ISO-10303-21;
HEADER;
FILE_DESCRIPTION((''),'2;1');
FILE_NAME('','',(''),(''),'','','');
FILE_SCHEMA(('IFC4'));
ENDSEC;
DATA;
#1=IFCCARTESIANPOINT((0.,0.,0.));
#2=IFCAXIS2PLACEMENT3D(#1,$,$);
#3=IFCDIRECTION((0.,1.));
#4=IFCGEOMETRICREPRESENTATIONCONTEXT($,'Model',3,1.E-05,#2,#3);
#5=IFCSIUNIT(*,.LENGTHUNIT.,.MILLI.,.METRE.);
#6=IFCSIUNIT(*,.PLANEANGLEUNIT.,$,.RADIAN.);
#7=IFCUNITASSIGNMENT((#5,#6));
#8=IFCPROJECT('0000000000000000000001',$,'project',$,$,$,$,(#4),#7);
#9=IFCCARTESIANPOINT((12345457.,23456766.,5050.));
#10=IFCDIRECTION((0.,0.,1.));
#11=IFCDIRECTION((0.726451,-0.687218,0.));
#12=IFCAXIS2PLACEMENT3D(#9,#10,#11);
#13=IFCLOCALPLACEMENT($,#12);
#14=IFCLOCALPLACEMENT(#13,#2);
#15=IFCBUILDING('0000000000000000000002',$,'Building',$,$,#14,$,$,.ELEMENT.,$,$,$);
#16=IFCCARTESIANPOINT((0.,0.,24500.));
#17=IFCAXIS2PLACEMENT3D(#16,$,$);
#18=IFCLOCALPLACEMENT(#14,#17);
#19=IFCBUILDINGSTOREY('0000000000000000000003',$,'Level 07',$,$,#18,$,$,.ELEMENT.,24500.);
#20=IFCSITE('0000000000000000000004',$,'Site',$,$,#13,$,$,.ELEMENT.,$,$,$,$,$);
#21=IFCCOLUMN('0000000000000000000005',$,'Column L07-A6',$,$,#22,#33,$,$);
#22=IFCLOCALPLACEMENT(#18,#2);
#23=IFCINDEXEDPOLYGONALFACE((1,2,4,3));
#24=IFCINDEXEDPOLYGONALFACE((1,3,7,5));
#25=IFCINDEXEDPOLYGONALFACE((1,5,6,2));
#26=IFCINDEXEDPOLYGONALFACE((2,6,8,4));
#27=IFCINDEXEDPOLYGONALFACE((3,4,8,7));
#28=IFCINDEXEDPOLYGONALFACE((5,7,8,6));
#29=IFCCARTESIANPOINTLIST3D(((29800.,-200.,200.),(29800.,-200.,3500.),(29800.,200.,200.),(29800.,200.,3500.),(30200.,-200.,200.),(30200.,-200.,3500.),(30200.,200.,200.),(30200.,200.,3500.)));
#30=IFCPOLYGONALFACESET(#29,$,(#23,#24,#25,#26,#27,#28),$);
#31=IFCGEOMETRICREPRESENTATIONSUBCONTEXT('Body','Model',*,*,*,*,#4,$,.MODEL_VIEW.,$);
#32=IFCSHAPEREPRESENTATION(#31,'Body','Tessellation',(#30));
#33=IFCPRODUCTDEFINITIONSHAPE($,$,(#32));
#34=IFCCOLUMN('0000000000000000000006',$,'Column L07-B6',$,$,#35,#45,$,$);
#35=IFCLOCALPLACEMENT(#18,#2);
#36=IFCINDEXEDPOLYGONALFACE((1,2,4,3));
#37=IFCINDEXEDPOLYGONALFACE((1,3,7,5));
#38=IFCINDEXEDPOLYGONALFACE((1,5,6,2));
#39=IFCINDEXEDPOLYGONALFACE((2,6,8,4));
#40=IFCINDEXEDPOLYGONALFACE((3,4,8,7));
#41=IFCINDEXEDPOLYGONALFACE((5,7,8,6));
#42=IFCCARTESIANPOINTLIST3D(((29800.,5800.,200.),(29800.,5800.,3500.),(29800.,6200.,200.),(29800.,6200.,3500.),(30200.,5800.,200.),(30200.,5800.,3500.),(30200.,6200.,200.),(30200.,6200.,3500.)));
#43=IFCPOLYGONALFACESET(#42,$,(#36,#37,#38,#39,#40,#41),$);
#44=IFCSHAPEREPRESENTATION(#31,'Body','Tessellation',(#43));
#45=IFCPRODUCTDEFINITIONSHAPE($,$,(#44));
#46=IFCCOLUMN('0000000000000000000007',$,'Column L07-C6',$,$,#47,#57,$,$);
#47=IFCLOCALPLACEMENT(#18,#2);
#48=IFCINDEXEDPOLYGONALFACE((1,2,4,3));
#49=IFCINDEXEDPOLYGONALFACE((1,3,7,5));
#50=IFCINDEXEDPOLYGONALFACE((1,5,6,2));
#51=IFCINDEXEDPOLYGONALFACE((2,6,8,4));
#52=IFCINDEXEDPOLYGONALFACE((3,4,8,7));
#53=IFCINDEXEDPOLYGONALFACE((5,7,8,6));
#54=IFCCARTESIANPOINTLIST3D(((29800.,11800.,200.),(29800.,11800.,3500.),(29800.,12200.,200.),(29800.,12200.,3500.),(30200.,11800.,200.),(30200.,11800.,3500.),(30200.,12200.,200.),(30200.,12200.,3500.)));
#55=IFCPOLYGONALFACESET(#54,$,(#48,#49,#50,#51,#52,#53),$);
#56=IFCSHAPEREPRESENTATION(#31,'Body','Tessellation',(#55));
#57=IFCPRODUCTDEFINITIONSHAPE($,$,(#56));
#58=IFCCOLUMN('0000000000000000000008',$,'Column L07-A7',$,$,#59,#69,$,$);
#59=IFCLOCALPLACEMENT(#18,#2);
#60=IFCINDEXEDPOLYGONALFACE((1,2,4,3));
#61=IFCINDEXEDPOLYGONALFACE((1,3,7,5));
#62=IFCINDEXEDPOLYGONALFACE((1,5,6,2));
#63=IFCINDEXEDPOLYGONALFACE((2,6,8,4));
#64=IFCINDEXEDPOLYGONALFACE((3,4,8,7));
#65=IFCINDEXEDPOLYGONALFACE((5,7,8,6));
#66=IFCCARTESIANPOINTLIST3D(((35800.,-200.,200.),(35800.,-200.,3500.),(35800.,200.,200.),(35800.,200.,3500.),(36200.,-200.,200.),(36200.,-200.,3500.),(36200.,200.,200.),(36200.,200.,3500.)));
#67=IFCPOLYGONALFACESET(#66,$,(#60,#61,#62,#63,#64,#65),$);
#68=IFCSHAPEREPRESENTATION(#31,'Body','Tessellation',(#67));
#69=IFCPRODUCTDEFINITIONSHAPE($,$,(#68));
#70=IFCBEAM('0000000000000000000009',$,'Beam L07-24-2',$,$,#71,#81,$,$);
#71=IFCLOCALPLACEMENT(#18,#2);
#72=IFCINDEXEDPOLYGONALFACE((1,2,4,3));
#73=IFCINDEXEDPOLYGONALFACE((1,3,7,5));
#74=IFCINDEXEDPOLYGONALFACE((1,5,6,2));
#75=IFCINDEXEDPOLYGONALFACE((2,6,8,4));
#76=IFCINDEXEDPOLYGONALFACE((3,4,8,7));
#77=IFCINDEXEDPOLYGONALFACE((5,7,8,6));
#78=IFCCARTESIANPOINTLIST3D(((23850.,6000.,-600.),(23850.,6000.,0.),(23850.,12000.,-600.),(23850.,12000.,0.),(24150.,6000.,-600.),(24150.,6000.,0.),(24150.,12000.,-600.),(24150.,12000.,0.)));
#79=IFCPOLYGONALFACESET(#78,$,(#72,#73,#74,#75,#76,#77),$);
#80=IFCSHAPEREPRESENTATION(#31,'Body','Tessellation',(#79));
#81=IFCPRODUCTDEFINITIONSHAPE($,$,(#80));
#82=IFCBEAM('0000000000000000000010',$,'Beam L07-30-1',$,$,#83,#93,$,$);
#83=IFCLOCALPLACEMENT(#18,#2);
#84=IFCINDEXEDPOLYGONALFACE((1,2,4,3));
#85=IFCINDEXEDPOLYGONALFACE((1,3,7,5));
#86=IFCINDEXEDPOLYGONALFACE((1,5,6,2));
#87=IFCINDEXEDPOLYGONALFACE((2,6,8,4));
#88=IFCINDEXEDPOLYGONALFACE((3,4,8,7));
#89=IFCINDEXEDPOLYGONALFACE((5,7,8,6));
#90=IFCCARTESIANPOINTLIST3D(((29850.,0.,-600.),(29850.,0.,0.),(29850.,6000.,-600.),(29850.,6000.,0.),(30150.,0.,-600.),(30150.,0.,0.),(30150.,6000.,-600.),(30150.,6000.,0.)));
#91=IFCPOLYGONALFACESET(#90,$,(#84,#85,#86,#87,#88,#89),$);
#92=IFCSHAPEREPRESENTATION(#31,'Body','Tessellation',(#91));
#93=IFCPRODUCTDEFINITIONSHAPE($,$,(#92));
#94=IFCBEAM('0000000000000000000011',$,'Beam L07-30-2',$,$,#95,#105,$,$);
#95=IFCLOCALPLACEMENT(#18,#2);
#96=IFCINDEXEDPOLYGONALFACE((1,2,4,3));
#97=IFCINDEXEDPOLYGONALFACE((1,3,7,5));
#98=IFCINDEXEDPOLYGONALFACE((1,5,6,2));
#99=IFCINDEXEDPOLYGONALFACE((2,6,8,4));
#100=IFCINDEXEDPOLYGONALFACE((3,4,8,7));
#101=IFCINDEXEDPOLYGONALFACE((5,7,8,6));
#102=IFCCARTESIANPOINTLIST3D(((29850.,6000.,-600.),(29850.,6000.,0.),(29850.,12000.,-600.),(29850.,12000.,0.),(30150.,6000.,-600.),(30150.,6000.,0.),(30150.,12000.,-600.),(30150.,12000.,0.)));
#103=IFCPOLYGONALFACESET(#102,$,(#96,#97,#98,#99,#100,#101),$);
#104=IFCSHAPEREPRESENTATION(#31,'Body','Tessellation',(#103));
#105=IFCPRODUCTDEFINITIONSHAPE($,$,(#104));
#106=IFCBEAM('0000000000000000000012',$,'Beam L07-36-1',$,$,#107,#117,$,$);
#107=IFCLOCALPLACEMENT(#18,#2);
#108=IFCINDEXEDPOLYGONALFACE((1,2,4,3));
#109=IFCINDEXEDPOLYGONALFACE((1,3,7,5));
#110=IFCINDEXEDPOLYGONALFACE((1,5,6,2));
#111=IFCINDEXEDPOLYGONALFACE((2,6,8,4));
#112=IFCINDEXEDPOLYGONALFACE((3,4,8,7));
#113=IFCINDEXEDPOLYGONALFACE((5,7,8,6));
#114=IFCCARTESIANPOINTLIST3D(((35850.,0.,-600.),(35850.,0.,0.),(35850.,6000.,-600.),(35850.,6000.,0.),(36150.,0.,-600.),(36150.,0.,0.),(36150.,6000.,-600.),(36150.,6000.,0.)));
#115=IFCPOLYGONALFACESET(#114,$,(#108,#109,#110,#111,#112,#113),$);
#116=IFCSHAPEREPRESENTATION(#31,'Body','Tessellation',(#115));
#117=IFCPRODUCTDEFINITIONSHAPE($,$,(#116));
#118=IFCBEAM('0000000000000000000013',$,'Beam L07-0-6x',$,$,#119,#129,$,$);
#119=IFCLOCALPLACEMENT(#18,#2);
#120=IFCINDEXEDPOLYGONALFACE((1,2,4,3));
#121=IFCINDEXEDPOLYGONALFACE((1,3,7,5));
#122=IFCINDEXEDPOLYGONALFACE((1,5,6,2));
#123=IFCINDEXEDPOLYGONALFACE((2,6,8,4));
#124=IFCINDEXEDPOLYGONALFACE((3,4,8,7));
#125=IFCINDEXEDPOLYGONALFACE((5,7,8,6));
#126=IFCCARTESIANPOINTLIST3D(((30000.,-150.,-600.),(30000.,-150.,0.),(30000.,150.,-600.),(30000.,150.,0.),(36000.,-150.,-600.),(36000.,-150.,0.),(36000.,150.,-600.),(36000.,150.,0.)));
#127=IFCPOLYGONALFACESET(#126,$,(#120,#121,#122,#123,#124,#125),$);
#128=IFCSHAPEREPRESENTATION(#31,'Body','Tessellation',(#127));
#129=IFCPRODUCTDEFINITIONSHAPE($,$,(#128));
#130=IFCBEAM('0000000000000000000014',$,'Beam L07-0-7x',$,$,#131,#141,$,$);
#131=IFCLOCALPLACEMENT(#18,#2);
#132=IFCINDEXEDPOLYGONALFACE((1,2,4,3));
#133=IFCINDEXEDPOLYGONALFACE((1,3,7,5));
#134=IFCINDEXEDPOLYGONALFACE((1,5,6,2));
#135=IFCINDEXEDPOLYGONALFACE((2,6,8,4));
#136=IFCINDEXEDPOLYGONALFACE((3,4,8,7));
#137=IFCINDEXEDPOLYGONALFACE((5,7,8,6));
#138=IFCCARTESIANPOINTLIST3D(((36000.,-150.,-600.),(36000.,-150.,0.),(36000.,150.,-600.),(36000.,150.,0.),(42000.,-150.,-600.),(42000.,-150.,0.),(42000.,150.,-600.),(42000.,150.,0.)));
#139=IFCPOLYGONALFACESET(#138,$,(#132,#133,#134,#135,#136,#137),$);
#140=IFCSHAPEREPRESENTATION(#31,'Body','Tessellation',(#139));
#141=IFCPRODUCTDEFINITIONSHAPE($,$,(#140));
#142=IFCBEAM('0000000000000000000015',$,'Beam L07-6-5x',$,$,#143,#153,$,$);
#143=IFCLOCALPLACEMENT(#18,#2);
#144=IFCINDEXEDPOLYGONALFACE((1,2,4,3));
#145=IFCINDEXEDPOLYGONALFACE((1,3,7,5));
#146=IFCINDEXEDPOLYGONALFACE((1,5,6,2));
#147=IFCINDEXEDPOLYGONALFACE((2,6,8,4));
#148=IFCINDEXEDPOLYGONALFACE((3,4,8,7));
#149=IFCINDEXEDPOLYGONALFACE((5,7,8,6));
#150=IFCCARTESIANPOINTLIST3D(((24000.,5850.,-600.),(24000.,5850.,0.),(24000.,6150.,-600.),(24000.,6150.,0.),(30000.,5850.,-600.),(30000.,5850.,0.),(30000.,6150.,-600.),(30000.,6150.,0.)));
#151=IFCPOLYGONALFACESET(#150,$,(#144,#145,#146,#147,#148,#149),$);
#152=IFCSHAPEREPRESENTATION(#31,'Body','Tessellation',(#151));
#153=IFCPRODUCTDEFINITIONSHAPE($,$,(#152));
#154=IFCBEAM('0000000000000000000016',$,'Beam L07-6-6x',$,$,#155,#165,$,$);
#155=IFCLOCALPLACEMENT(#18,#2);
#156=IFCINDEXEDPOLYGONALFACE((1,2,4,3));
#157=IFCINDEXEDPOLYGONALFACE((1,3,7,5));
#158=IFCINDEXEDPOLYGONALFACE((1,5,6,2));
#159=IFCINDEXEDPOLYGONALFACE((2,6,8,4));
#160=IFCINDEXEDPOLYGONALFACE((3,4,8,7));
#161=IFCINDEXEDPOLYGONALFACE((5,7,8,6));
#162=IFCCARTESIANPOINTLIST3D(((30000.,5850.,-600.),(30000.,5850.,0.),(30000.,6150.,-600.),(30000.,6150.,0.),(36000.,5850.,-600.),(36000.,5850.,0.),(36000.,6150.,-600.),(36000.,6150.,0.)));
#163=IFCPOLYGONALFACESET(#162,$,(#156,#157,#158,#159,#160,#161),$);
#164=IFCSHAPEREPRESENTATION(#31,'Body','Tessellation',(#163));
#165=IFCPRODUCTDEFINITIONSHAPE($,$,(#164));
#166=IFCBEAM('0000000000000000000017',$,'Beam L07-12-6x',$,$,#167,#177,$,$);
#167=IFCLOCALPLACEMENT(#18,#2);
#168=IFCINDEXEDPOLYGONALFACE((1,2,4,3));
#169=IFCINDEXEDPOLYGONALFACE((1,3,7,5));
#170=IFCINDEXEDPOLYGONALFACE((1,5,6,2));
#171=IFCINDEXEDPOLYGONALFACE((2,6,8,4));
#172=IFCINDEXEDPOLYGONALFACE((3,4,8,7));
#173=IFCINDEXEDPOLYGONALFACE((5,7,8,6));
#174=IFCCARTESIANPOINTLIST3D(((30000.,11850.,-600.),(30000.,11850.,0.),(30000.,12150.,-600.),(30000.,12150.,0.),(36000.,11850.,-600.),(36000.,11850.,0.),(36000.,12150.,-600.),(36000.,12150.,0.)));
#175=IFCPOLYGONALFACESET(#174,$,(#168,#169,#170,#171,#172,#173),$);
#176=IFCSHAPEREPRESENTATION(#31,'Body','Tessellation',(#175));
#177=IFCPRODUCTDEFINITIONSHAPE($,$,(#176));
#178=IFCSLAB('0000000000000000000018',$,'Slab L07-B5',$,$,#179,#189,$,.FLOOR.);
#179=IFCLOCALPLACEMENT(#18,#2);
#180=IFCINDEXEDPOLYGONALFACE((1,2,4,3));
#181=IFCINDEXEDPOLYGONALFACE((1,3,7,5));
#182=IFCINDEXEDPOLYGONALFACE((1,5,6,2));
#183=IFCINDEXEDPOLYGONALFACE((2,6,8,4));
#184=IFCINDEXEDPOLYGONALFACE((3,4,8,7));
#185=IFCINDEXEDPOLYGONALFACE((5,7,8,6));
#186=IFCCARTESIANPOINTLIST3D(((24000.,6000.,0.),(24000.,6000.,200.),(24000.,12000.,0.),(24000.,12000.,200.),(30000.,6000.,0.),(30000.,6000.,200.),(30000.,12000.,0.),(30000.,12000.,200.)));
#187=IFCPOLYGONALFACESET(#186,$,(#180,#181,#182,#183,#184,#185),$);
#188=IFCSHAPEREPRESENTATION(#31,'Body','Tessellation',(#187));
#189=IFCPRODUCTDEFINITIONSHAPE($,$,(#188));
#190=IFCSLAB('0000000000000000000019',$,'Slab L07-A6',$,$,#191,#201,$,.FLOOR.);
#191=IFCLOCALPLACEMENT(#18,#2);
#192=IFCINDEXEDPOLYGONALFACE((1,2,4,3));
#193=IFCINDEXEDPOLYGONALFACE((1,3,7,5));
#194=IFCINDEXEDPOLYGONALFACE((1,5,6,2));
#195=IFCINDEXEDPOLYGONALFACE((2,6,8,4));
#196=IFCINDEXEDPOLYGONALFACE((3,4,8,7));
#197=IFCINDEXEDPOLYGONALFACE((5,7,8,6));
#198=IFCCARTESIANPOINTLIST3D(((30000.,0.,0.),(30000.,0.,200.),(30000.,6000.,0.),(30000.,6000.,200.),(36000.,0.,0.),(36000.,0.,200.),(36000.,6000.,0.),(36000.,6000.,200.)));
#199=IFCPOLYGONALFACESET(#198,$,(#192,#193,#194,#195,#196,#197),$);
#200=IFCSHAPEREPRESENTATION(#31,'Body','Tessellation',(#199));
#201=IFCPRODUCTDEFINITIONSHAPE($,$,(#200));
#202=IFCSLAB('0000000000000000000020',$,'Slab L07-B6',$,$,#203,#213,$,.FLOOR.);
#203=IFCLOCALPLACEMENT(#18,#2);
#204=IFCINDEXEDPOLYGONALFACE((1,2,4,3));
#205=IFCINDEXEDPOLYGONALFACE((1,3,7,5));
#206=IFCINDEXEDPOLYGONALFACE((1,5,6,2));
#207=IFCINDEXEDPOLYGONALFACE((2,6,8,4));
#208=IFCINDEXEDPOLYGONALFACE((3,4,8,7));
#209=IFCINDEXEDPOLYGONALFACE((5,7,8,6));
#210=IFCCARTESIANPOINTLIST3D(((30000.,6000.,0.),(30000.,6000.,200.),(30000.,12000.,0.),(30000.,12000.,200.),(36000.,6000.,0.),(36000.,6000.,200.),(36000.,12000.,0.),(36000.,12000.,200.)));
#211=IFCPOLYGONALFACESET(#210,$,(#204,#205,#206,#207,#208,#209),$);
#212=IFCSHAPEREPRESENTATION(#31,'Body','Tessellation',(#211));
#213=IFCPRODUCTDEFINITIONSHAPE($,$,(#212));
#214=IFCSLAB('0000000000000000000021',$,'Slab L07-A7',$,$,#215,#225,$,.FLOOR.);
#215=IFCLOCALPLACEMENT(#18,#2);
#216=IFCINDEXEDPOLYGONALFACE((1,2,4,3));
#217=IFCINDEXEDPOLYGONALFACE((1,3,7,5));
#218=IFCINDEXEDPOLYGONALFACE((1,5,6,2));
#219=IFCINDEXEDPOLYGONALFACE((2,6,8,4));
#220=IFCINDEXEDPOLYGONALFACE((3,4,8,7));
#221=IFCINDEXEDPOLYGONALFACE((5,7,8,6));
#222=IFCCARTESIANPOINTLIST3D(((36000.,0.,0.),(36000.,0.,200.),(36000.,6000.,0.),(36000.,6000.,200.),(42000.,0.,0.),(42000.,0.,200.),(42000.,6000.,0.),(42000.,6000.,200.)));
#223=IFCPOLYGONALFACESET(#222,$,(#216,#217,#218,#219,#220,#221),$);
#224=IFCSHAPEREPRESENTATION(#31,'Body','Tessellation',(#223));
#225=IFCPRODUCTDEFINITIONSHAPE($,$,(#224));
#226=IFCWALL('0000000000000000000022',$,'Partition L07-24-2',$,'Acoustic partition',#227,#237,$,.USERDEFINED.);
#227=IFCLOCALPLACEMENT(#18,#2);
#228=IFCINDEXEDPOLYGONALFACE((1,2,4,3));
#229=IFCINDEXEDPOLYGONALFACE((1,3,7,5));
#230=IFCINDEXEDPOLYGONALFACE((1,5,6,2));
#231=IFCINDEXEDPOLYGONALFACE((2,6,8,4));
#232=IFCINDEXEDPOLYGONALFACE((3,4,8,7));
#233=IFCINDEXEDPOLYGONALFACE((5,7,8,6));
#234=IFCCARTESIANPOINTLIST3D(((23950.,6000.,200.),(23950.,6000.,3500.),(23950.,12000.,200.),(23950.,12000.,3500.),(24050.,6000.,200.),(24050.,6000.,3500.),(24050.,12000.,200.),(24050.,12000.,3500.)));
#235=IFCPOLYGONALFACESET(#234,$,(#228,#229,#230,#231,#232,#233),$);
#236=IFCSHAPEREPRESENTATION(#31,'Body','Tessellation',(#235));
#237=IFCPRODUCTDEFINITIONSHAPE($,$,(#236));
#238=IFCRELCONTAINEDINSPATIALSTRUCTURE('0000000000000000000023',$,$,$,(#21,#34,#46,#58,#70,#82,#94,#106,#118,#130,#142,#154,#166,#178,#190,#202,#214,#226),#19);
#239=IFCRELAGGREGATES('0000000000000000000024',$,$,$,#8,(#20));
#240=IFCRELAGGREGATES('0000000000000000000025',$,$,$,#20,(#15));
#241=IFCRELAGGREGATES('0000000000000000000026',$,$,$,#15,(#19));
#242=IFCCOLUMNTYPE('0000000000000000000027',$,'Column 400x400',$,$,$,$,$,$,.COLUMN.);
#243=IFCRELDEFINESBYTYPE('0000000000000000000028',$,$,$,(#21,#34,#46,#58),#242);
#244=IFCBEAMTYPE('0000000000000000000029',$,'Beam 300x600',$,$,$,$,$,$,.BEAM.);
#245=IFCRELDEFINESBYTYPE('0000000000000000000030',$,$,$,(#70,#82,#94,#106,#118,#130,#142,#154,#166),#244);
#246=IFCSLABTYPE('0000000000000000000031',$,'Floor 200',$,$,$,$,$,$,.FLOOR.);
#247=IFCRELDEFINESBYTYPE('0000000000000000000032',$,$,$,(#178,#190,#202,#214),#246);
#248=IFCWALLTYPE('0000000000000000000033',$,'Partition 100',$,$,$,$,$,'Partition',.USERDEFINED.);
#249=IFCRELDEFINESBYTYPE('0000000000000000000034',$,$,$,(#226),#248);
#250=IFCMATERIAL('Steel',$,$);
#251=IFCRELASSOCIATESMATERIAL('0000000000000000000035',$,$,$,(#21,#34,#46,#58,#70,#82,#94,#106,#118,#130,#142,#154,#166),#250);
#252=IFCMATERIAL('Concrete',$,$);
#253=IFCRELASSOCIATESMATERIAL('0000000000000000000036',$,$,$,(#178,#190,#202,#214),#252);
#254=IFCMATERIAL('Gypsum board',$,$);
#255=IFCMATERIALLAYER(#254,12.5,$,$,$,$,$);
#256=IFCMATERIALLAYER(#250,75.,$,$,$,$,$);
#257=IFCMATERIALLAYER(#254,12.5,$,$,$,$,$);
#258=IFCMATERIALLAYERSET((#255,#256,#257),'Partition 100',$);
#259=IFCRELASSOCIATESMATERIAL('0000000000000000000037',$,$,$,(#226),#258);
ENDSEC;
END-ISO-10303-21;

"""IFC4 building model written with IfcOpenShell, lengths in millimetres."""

from ifc_helpers import new_model, si_unit, direction, frame, origin, place, context, subcontext, project, spatial, rectangle, extrude, material, layer, layer_set, layer_usage, type_object, element, save


model = new_model("IFC4")

# Units and contexts
model_context = context("Model", 3, precision=1e-05, world=origin(), true_north=direction((0.0, 1.0)))
body_context = subcontext(model_context, "Body", "Model", "MODEL_VIEW")
ifc_project = project(units=[si_unit("LENGTHUNIT", "METRE", prefix="MILLI"), si_unit("PLANEANGLEUNIT", "RADIAN")], contexts=[model_context])

# Site, building, storey
site_placement = place(None, frame((12345457.0, 23456766.0, 5050.0), z_axis=(0.0, 0.0, 1.0), x_axis=(0.726451, -0.687218, 0.0)))
site = spatial("IfcSite", under=ifc_project, at=site_placement, Name="Site", CompositionType="ELEMENT")
building_placement = place(site_placement, origin())
building = spatial("IfcBuilding", under=site, at=building_placement, Name="Building", CompositionType="ELEMENT")
storey_placement = place(building_placement, frame((0.0, 0.0, 24500.0)))
storey = spatial("IfcBuildingStorey", under=building, at=storey_placement, Name="Level 07", CompositionType="ELEMENT", Elevation=24500.0)

# Columns
ifc_material_1 = material(Name="Steel")
column_type = type_object("IfcColumnType", Name="Column 400x400", PredefinedType="COLUMN")
for number, where, name in (
    (1, (29800.0, -200.0, 200.0), "Column L07-A6"),
    (2, (29800.0, 5800.0, 200.0), "Column L07-B6"),
    (3, (29800.0, 11800.0, 200.0), "Column L07-C6"),
    (4, (35800.0, -200.0, 200.0), "Column L07-A7"),
):
    element("IfcColumn", number, at=place(storey_placement, frame(where)), inside=storey, type_object=column_type, material=ifc_material_1, Name=name, context=body_context, shape_type="SweptSolid", body=[
        extrude(rectangle(XDim=400.0, YDim=400.0), frame((200.0, 200.0, 0.0)), (0.0, 0.0, 1.0), 3300.0),
    ])

# Beams
beam_type = type_object("IfcBeamType", Name="Beam 300x600", PredefinedType="BEAM")
for number, where, name in (
    (5, (23850.0, 6000.0, -600.0), "Beam L07-24-2"),
    (6, (29850.0, 0.0, -600.0), "Beam L07-30-1"),
    (7, (29850.0, 6000.0, -600.0), "Beam L07-30-2"),
    (8, (35850.0, 0.0, -600.0), "Beam L07-36-1"),
):
    element("IfcBeam", number, at=place(storey_placement, frame(where)), inside=storey, type_object=beam_type, material=ifc_material_1, Name=name, context=body_context, shape_type="SweptSolid", body=[
        extrude(rectangle(XDim=300.0, YDim=6000.0), frame((150.0, 3000.0, 0.0)), (0.0, 0.0, 1.0), 600.0),
    ])
for number, where, name in (
    (9, (30000.0, -150.0, -600.0), "Beam L07-0-6x"),
    (10, (36000.0, -150.0, -600.0), "Beam L07-0-7x"),
    (11, (24000.0, 5850.0, -600.0), "Beam L07-6-5x"),
    (12, (30000.0, 5850.0, -600.0), "Beam L07-6-6x"),
    (13, (30000.0, 11850.0, -600.0), "Beam L07-12-6x"),
):
    element("IfcBeam", number, at=place(storey_placement, frame(where)), inside=storey, type_object=beam_type, material=ifc_material_1, Name=name, context=body_context, shape_type="SweptSolid", body=[
        extrude(rectangle(XDim=6000.0, YDim=300.0), frame((3000.0, 150.0, 0.0)), (0.0, 0.0, 1.0), 600.0),
    ])

# Slabs
ifc_material_2 = material(Name="Concrete")
slab_type = type_object("IfcSlabType", Name="Floor 200", PredefinedType="FLOOR")
for number, where, name in (
    (14, (24000.0, 6000.0, 0.0), "Slab L07-B5"),
    (15, (30000.0, 0.0, 0.0), "Slab L07-A6"),
    (16, (30000.0, 6000.0, 0.0), "Slab L07-B6"),
    (17, (36000.0, 0.0, 0.0), "Slab L07-A7"),
):
    element("IfcSlab", number, at=place(storey_placement, frame(where)), inside=storey, type_object=slab_type, material=ifc_material_2, Name=name, PredefinedType="FLOOR", context=body_context, shape_type="SweptSolid", body=[
        extrude(rectangle(XDim=6000.0, YDim=6000.0), frame((3000.0, 3000.0, 0.0)), (0.0, 0.0, 1.0), 200.0),
    ])

# Wall
ifc_material_3 = material(Name="Gypsum board")
ifc_layer_1 = layer(ifc_material_3, 12.5)
ifc_layer_2 = layer(ifc_material_1, 75.0)
ifc_layer_3 = layer(ifc_material_3, 12.5)
ifc_layer_set = layer_set([ifc_layer_1, ifc_layer_2, ifc_layer_3], Name="Partition 100")
ifc_layer_usage = layer_usage(ifc_layer_set, "AXIS2", "POSITIVE", 0.0)
wall_type = type_object("IfcWallType", Name="Partition 100", ElementType="Partition", PredefinedType="USERDEFINED")
for number, where, name in (
    (18, (23950.0, 6000.0, 200.0), "Partition L07-24-2"),
):
    element("IfcWall", number, at=place(storey_placement, frame(where)), inside=storey, type_object=wall_type, material=ifc_layer_usage, Name=name, ObjectType="Acoustic partition", PredefinedType="USERDEFINED", context=body_context, shape_type="SweptSolid", body=[
        extrude(rectangle(XDim=100.0, YDim=6000.0), frame((50.0, 3000.0, 0.0)), (0.0, 0.0, 1.0), 3300.0),
    ])

save(model, "model.ifc")
